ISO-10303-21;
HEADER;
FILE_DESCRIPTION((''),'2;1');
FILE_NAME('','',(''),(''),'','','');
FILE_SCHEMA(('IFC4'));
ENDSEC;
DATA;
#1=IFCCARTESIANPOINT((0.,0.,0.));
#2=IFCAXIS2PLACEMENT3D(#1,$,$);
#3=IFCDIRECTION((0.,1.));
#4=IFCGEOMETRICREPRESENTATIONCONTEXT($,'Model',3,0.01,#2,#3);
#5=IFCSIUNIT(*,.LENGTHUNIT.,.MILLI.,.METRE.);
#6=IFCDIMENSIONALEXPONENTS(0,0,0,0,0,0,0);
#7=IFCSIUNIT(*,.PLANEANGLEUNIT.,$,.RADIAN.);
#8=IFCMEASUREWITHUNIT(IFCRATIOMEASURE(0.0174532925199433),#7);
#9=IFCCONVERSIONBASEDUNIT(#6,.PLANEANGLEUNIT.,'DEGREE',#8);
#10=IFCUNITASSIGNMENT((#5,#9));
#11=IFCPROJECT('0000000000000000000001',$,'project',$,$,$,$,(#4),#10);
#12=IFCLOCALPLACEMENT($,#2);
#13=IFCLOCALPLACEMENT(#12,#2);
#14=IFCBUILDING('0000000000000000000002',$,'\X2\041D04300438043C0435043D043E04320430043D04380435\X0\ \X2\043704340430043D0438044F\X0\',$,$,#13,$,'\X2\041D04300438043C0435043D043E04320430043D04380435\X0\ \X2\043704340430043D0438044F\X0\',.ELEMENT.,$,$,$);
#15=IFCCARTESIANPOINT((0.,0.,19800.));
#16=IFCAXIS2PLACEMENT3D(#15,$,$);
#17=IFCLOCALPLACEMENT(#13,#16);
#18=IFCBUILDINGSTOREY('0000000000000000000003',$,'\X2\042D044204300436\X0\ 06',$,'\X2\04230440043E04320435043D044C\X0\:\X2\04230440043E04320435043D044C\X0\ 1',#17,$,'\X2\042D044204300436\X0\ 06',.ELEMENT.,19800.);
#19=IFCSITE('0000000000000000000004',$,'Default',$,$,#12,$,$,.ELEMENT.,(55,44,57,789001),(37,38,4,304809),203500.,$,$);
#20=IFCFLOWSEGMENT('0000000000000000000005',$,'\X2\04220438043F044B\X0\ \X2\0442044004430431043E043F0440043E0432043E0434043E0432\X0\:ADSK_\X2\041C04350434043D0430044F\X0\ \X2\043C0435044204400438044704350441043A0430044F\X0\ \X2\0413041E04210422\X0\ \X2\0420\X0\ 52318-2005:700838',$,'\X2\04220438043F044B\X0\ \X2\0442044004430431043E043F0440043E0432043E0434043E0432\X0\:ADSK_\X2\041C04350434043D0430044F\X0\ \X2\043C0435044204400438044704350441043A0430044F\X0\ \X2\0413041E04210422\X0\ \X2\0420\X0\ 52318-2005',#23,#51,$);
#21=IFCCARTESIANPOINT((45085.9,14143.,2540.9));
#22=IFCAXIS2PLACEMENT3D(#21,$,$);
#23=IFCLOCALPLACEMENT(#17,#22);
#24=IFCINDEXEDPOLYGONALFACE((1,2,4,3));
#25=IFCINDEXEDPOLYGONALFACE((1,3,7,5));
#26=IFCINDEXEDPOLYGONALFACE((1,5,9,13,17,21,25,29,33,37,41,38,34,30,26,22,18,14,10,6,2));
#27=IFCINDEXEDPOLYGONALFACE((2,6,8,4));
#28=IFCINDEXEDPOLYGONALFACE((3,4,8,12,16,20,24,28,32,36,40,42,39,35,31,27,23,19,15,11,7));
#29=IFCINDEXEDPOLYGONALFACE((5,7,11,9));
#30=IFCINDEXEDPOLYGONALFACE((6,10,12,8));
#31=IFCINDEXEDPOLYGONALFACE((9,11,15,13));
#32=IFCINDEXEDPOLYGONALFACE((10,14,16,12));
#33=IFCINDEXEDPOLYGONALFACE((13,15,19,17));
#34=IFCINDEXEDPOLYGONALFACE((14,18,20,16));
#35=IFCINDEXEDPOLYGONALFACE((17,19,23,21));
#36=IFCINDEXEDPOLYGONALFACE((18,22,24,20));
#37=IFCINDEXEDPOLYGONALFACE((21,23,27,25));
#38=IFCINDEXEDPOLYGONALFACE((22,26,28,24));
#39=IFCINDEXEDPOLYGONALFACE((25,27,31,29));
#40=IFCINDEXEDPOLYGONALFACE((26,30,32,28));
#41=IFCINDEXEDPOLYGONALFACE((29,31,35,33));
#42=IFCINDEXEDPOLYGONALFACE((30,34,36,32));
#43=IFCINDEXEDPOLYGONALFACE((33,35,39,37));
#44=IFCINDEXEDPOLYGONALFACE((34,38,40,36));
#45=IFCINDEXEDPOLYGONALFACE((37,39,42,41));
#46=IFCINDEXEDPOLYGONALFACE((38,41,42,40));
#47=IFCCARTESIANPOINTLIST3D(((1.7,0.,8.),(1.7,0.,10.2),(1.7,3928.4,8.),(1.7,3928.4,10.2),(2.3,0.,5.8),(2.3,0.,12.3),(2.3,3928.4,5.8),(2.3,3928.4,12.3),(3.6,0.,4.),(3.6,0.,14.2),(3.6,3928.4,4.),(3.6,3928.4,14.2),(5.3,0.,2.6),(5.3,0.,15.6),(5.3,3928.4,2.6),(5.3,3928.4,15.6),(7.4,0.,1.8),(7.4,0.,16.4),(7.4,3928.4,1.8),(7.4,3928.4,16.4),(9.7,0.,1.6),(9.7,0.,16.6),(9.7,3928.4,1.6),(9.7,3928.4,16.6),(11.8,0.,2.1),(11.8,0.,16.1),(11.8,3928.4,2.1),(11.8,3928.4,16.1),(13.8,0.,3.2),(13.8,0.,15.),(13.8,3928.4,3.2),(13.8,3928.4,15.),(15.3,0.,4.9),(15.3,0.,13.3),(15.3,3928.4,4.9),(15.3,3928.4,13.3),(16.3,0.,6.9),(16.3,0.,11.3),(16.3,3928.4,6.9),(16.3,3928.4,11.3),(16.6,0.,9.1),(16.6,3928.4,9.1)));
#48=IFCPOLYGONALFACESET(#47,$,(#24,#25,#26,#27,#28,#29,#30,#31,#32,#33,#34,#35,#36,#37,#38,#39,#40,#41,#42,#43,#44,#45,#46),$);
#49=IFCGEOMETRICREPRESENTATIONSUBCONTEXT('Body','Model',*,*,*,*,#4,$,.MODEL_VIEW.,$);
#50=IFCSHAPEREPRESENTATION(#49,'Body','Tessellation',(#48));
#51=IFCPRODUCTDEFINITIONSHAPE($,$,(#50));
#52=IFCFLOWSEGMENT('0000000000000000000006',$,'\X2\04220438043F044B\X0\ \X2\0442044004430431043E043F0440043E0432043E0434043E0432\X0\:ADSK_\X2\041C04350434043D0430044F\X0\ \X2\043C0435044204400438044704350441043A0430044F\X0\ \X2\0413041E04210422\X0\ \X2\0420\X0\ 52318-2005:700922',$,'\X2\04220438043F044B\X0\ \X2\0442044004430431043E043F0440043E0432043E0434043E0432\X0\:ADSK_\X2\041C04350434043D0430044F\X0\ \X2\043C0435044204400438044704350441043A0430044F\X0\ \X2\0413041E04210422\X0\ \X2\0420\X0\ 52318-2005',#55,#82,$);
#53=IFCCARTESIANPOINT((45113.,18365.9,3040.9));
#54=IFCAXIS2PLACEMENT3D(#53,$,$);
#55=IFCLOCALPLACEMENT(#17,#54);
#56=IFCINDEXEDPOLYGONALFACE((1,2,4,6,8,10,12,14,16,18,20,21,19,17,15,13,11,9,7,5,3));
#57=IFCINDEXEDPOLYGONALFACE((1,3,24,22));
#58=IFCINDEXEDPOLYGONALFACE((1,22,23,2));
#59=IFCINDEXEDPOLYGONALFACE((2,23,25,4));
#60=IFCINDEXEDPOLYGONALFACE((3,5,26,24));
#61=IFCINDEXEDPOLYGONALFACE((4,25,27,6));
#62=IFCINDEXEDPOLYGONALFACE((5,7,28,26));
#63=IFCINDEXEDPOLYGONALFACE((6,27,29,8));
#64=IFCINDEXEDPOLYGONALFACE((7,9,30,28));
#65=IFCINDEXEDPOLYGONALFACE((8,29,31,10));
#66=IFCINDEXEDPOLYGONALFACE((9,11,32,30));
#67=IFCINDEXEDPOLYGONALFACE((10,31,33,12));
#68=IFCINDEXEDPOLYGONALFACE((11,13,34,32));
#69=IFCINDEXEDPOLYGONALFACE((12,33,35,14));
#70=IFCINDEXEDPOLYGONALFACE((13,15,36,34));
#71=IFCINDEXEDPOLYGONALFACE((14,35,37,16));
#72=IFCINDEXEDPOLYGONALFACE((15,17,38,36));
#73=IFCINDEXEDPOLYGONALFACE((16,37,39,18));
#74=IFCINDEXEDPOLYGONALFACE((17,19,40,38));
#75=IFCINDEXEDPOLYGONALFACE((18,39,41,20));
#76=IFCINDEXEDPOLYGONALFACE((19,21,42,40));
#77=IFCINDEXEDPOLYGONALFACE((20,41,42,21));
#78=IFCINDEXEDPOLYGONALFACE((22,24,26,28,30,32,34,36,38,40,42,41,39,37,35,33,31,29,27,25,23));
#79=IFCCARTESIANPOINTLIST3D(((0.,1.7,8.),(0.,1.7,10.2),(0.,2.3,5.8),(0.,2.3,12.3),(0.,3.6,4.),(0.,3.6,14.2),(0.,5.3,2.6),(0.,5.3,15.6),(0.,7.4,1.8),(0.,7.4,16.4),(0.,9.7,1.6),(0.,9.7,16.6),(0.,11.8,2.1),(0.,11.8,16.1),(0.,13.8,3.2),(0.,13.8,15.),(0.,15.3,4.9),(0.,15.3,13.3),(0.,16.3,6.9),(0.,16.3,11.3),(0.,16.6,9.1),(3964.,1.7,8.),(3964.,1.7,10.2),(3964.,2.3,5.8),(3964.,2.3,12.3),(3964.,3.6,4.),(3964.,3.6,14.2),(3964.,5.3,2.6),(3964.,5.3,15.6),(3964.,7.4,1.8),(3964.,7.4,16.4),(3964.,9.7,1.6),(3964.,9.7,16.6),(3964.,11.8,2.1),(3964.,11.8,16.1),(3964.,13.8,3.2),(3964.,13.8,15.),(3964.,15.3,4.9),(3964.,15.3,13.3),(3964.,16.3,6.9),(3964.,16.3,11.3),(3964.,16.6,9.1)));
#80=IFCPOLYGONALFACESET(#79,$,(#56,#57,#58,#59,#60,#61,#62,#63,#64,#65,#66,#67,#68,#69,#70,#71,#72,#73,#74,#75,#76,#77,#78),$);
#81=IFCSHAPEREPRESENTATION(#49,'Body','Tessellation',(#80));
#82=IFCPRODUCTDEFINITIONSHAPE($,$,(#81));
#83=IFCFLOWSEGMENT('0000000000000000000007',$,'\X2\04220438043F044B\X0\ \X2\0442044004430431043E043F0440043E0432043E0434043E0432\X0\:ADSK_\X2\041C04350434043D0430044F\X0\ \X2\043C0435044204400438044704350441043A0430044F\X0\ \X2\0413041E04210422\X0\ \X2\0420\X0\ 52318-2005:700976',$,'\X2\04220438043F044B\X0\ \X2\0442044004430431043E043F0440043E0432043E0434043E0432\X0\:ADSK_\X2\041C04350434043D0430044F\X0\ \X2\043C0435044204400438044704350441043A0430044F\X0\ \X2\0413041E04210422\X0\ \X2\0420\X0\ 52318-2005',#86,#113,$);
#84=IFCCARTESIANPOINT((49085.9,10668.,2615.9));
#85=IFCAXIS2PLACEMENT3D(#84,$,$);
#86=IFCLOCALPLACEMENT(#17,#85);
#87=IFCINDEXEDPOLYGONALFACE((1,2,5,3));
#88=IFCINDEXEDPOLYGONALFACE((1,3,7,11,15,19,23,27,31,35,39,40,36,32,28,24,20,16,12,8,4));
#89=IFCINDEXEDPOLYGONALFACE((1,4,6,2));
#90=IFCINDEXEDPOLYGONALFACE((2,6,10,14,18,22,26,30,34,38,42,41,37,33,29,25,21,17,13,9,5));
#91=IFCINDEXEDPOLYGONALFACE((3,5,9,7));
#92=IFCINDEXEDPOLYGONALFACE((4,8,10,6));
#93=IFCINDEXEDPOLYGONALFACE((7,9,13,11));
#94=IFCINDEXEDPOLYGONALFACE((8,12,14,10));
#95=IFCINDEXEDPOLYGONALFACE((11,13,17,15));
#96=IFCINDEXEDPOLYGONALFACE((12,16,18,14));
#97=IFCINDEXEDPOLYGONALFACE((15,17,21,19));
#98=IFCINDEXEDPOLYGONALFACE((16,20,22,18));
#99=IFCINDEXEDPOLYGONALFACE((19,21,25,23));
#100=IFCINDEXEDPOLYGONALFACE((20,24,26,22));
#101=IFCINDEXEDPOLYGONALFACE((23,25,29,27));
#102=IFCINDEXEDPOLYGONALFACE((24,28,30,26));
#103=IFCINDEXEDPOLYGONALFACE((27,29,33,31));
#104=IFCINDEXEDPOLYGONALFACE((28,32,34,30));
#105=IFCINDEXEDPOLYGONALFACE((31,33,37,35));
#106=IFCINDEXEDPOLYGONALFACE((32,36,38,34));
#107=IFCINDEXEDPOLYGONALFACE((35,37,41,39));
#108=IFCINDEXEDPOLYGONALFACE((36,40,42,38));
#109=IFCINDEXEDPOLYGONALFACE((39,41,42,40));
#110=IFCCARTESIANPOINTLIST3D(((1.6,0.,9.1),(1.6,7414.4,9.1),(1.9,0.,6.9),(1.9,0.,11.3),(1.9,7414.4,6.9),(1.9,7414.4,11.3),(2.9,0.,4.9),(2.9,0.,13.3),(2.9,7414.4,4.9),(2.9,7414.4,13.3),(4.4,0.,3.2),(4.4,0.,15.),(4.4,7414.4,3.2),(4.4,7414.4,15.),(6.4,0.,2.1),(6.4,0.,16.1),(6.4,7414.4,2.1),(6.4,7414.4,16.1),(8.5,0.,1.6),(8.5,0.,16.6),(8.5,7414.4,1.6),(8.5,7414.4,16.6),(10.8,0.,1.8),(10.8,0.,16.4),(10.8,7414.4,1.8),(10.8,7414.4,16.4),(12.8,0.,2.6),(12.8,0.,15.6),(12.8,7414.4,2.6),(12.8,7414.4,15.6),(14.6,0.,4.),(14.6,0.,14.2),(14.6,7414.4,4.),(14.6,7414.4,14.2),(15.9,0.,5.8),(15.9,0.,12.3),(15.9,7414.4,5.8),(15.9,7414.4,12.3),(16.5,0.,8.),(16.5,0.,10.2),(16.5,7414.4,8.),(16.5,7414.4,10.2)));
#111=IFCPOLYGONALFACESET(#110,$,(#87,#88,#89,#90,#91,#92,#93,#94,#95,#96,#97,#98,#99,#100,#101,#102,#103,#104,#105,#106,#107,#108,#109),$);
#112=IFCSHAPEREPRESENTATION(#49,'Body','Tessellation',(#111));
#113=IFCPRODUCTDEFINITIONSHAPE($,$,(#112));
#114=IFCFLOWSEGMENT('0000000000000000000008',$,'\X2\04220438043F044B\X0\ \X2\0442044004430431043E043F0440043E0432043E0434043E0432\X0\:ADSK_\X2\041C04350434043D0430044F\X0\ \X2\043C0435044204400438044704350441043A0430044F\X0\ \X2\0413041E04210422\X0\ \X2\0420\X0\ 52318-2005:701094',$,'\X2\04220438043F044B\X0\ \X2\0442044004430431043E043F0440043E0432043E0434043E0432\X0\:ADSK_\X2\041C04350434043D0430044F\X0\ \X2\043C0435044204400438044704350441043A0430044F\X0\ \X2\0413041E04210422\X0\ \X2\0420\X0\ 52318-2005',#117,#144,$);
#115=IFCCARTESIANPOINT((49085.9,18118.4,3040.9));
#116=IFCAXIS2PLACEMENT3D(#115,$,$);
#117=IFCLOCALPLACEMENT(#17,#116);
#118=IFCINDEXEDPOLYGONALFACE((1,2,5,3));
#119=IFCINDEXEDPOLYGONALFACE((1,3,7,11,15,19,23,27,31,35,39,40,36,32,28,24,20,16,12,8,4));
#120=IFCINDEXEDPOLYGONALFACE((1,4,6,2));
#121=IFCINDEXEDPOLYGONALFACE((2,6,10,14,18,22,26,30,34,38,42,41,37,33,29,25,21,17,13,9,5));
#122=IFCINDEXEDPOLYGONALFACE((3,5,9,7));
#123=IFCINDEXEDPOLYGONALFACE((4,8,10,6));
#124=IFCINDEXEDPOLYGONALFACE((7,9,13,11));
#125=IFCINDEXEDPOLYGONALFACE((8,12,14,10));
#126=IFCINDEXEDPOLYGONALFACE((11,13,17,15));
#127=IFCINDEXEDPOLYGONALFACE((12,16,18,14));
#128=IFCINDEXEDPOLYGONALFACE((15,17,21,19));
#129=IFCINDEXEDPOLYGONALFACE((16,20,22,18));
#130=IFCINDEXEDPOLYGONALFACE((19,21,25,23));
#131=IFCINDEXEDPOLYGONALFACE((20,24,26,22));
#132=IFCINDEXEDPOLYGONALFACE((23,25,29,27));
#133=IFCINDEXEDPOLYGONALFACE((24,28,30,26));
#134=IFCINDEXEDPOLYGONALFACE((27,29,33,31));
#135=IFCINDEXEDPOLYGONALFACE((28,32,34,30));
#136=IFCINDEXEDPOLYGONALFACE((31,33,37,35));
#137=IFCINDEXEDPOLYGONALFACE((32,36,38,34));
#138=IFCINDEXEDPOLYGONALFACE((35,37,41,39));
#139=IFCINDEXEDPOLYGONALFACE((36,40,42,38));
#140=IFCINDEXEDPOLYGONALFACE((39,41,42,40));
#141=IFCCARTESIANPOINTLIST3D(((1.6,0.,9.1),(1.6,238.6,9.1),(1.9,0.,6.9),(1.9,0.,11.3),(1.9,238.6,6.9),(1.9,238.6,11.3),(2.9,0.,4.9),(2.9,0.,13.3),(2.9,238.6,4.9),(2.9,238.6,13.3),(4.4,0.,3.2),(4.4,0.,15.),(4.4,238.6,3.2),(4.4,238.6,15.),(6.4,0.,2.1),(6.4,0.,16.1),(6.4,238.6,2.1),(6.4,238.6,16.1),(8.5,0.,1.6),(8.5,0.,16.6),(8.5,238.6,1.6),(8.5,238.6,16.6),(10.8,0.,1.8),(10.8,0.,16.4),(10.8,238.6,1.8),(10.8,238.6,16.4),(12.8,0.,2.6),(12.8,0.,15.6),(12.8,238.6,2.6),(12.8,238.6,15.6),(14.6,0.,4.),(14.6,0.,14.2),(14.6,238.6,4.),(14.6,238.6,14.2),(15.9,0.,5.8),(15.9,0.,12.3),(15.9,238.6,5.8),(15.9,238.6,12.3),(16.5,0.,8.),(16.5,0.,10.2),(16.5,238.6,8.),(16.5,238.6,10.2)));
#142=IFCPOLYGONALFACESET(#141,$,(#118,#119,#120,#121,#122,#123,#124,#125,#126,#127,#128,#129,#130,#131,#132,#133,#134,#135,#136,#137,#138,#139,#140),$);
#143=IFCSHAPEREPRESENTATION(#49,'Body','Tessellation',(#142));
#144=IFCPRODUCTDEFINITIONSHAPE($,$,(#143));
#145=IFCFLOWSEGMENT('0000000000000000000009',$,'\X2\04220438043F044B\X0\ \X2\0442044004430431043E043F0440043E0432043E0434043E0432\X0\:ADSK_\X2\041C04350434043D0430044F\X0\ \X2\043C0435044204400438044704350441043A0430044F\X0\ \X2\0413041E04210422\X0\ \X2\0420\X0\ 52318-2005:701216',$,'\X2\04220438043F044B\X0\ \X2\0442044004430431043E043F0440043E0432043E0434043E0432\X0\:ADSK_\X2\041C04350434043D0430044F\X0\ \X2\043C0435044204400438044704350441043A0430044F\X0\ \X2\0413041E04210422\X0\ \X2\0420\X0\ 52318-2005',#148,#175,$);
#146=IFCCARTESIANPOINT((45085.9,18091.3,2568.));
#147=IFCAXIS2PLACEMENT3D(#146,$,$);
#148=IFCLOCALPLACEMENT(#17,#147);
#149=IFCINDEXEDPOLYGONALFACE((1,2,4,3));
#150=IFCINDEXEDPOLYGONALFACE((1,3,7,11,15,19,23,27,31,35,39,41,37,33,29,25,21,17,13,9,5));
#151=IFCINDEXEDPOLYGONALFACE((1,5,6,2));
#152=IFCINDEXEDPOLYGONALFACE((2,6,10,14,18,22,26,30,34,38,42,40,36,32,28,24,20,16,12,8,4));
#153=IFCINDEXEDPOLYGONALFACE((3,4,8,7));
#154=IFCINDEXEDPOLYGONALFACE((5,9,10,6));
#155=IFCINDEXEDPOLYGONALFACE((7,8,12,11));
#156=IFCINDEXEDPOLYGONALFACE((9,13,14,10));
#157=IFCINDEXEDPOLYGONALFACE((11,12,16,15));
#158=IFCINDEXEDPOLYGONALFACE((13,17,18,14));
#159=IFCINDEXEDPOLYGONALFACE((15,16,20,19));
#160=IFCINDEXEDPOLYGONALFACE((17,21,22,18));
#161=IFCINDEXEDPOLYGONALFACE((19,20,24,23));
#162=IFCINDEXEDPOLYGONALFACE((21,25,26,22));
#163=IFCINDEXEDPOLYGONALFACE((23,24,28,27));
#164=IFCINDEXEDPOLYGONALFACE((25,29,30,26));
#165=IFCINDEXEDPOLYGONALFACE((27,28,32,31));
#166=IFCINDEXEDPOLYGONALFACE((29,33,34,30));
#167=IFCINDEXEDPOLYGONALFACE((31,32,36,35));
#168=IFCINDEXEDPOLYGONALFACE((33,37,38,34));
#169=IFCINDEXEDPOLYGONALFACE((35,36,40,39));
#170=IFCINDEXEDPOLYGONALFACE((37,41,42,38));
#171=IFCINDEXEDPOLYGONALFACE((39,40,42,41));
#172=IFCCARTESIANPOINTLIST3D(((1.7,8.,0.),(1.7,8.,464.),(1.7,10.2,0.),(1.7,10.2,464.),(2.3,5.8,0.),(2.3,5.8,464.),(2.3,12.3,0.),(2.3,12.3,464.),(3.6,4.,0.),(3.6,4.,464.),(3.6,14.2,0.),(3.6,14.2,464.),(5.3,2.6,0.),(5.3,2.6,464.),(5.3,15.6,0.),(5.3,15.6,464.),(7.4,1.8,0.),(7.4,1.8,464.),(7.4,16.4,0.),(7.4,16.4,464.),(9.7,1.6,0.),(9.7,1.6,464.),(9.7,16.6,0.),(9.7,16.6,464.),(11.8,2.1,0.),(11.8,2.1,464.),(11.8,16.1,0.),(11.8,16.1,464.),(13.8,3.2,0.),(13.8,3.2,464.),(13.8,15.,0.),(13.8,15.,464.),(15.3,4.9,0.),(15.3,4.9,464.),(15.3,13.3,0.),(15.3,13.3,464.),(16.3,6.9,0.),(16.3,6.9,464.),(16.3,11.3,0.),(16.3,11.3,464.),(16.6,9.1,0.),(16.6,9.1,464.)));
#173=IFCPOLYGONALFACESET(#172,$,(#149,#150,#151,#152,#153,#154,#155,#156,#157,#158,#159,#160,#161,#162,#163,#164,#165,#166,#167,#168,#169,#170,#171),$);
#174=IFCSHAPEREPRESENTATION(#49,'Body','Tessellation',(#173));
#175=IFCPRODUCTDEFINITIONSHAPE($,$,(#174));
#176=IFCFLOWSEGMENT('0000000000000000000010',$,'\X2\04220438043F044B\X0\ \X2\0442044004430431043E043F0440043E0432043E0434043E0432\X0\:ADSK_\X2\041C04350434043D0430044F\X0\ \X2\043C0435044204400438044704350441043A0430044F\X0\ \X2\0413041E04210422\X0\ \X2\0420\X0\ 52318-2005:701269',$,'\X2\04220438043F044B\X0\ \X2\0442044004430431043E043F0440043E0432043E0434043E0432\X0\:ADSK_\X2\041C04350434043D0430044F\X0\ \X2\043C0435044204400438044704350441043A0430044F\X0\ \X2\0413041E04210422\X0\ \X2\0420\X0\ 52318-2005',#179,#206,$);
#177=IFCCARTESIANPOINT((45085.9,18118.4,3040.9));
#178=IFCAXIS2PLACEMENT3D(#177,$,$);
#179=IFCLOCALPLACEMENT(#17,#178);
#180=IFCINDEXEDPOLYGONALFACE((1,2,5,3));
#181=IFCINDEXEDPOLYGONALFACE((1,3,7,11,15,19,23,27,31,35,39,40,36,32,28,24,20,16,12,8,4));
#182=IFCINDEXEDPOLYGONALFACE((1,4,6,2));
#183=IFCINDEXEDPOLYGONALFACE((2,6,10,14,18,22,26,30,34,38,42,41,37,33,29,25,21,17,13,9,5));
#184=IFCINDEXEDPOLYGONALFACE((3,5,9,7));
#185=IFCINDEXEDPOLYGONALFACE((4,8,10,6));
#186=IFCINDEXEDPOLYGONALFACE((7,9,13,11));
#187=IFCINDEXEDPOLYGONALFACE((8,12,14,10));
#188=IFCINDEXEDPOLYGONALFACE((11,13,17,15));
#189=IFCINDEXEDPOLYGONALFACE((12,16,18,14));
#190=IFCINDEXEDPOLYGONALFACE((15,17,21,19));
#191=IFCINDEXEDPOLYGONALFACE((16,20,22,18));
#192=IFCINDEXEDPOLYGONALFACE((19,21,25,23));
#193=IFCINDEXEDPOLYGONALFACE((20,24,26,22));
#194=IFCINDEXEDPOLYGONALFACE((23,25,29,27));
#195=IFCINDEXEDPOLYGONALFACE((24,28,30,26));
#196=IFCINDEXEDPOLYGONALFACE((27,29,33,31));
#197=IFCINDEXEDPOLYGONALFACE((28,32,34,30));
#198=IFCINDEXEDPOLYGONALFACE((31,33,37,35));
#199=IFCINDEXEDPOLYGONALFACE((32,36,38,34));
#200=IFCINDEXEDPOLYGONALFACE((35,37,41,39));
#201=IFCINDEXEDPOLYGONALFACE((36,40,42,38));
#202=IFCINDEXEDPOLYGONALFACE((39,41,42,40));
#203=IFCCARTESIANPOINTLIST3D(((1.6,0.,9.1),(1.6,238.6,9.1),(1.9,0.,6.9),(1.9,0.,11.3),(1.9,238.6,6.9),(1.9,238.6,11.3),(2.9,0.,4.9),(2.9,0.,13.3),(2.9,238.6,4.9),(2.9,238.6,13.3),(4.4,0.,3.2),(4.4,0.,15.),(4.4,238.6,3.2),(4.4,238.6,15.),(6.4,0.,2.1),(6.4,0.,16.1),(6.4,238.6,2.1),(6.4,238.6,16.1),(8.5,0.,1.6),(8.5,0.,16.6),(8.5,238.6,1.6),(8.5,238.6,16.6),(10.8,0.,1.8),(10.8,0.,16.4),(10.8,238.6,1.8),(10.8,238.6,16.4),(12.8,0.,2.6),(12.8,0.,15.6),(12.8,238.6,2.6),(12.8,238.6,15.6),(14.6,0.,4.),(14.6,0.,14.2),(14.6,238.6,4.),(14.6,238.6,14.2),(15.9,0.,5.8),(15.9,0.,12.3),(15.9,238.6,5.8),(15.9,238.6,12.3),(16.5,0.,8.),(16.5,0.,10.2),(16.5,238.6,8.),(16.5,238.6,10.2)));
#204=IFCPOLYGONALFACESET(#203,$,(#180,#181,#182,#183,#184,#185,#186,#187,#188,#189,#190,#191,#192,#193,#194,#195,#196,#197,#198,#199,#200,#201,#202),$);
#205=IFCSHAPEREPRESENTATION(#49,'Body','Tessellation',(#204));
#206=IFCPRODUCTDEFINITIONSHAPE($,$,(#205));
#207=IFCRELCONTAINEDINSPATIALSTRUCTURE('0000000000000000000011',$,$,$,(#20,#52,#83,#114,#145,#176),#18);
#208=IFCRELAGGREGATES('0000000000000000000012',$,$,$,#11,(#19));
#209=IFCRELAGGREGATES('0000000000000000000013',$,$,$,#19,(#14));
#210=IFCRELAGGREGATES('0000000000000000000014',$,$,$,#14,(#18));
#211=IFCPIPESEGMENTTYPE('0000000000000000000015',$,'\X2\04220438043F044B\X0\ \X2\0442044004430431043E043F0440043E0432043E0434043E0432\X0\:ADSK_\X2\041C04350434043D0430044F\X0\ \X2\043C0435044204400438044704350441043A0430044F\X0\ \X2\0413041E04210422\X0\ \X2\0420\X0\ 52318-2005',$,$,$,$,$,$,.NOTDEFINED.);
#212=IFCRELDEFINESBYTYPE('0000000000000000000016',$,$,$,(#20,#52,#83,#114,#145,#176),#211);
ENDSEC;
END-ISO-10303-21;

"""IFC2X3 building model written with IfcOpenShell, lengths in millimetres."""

from ifc_helpers import new_model, entity, si_unit, converted_unit, direction, frame, frame_2d, origin, origin_2d_with_axis, place, context, subcontext, project, spatial, circle, extrude, type_object, element, save


model = new_model("IFC2X3")

# Units and contexts
model_context = context("Model", 3, precision=0.01, world=origin(), true_north=direction((0.0, 1.0)))
body_context = subcontext(model_context, "Body", "Model", "MODEL_VIEW")
ifc_project = project(units=[si_unit("LENGTHUNIT", "METRE", prefix="MILLI"), converted_unit("PLANEANGLEUNIT", "DEGREE", entity("IfcRatioMeasure", 0.0174532925199433), si_unit("PLANEANGLEUNIT", "RADIAN"), dimensions=[0, 0, 0, 0, 0, 0, 0])], contexts=[model_context])

# Site, building, storey
site_placement = place(None, frame((0.0, 0.0, 0.0)))
site = spatial("IfcSite", under=ifc_project, at=site_placement, Name="Default", CompositionType="ELEMENT", RefLatitude=(55, 44, 57, 789001), RefLongitude=(37, 38, 4, 304809), RefElevation=203500.0)
building_placement = place(site_placement, origin())
building = spatial("IfcBuilding", under=site, at=building_placement, Name="Наименование здания", LongName="Наименование здания", CompositionType="ELEMENT")
storey_placement = place(building_placement, frame((0.0, 0.0, 19800.0)))
storey = spatial("IfcBuildingStorey", under=building, at=storey_placement, Name="Этаж 06", ObjectType="Уровень:Уровень 1", LongName="Этаж 06", CompositionType="ELEMENT", Elevation=19800.0)

# Flow segments
pipe_segment_type = type_object("IfcPipeSegmentType", Name="Типы трубопроводов:ADSK_Медная метрическая ГОСТ Р 52318-2005", PredefinedType="NOTDEFINED")
flow_segment_1_placement = place(storey_placement, frame((45085.9, 14143.0, 2540.9)))
element("IfcFlowSegment", 1, at=flow_segment_1_placement, inside=storey, type_object=pipe_segment_type, Name="Типы трубопроводов:ADSK_Медная метрическая ГОСТ Р 52318-2005:700838", ObjectType="Типы трубопроводов:ADSK_Медная метрическая ГОСТ Р 52318-2005", context=body_context, shape_type="SweptSolid", body=[
    extrude(circle(Radius=7.5, at=origin_2d_with_axis()), frame((9.1, 0.0, 9.1), z_axis=(0.0, 1.0, 0.0), x_axis=(1.0, 0.0, 0.0)), (0.0, 0.0, 1.0), 3928.4),
])
flow_segment_2_placement = place(storey_placement, frame((45113.0, 18365.9, 3040.9)))
element("IfcFlowSegment", 2, at=flow_segment_2_placement, inside=storey, type_object=pipe_segment_type, Name="Типы трубопроводов:ADSK_Медная метрическая ГОСТ Р 52318-2005:700922", ObjectType="Типы трубопроводов:ADSK_Медная метрическая ГОСТ Р 52318-2005", context=body_context, shape_type="SweptSolid", body=[
    extrude(circle(Radius=7.5, at=frame_2d((0.0, 0.0), x_axis=(1.0, 0.0))), frame((0.0, 9.1, 9.1), z_axis=(1.0, 0.0, 0.0), x_axis=(0.0, 1.0, 0.0)), (0.0, 0.0, 1.0), 3964.0),
])
flow_segment_3_placement = place(storey_placement, frame((49085.9, 10668.0, 2615.9)))
element("IfcFlowSegment", 3, at=flow_segment_3_placement, inside=storey, type_object=pipe_segment_type, Name="Типы трубопроводов:ADSK_Медная метрическая ГОСТ Р 52318-2005:700976", ObjectType="Типы трубопроводов:ADSK_Медная метрическая ГОСТ Р 52318-2005", context=body_context, shape_type="SweptSolid", body=[
    extrude(circle(Radius=7.5, at=origin_2d_with_axis()), frame((9.1, 0.0, 9.1), z_axis=(0.0, 1.0, 0.0), x_axis=(-1.0, 0.0, 0.0)), (0.0, 0.0, 1.0), 7414.4),
])
flow_segment_4_placement = place(storey_placement, frame((49085.9, 18118.4, 3040.9)))
element("IfcFlowSegment", 4, at=flow_segment_4_placement, inside=storey, type_object=pipe_segment_type, Name="Типы трубопроводов:ADSK_Медная метрическая ГОСТ Р 52318-2005:701094", ObjectType="Типы трубопроводов:ADSK_Медная метрическая ГОСТ Р 52318-2005", context=body_context, shape_type="SweptSolid", body=[
    extrude(circle(Radius=7.5, at=origin_2d_with_axis()), frame((9.1, 0.0, 9.1), z_axis=(0.0, 1.0, 0.0), x_axis=(-1.0, 0.0, 0.0)), (0.0, 0.0, 1.0), 238.6),
])
flow_segment_5_placement = place(storey_placement, frame((45085.9, 18091.3, 2568.0)))
element("IfcFlowSegment", 5, at=flow_segment_5_placement, inside=storey, type_object=pipe_segment_type, Name="Типы трубопроводов:ADSK_Медная метрическая ГОСТ Р 52318-2005:701216", ObjectType="Типы трубопроводов:ADSK_Медная метрическая ГОСТ Р 52318-2005", context=body_context, shape_type="SweptSolid", body=[
    extrude(circle(Radius=7.5, at=frame_2d((0.0, 0.0), x_axis=(1.0, 0.0))), frame((9.1, 9.1, 0.0)), (0.0, 0.0, 1.0), 464.0),
])
flow_segment_6_placement = place(storey_placement, frame((45085.9, 18118.4, 3040.9)))
element("IfcFlowSegment", 6, at=flow_segment_6_placement, inside=storey, type_object=pipe_segment_type, Name="Типы трубопроводов:ADSK_Медная метрическая ГОСТ Р 52318-2005:701269", ObjectType="Типы трубопроводов:ADSK_Медная метрическая ГОСТ Р 52318-2005", context=body_context, shape_type="SweptSolid", body=[
    extrude(circle(Radius=7.5, at=frame_2d((0.0, 0.0), x_axis=(1.0, 0.0))), frame((9.1, 0.0, 9.1), z_axis=(0.0, 1.0, 0.0), x_axis=(-1.0, 0.0, 0.0)), (0.0, 0.0, 1.0), 238.6),
])

save(model, "model.ifc")
